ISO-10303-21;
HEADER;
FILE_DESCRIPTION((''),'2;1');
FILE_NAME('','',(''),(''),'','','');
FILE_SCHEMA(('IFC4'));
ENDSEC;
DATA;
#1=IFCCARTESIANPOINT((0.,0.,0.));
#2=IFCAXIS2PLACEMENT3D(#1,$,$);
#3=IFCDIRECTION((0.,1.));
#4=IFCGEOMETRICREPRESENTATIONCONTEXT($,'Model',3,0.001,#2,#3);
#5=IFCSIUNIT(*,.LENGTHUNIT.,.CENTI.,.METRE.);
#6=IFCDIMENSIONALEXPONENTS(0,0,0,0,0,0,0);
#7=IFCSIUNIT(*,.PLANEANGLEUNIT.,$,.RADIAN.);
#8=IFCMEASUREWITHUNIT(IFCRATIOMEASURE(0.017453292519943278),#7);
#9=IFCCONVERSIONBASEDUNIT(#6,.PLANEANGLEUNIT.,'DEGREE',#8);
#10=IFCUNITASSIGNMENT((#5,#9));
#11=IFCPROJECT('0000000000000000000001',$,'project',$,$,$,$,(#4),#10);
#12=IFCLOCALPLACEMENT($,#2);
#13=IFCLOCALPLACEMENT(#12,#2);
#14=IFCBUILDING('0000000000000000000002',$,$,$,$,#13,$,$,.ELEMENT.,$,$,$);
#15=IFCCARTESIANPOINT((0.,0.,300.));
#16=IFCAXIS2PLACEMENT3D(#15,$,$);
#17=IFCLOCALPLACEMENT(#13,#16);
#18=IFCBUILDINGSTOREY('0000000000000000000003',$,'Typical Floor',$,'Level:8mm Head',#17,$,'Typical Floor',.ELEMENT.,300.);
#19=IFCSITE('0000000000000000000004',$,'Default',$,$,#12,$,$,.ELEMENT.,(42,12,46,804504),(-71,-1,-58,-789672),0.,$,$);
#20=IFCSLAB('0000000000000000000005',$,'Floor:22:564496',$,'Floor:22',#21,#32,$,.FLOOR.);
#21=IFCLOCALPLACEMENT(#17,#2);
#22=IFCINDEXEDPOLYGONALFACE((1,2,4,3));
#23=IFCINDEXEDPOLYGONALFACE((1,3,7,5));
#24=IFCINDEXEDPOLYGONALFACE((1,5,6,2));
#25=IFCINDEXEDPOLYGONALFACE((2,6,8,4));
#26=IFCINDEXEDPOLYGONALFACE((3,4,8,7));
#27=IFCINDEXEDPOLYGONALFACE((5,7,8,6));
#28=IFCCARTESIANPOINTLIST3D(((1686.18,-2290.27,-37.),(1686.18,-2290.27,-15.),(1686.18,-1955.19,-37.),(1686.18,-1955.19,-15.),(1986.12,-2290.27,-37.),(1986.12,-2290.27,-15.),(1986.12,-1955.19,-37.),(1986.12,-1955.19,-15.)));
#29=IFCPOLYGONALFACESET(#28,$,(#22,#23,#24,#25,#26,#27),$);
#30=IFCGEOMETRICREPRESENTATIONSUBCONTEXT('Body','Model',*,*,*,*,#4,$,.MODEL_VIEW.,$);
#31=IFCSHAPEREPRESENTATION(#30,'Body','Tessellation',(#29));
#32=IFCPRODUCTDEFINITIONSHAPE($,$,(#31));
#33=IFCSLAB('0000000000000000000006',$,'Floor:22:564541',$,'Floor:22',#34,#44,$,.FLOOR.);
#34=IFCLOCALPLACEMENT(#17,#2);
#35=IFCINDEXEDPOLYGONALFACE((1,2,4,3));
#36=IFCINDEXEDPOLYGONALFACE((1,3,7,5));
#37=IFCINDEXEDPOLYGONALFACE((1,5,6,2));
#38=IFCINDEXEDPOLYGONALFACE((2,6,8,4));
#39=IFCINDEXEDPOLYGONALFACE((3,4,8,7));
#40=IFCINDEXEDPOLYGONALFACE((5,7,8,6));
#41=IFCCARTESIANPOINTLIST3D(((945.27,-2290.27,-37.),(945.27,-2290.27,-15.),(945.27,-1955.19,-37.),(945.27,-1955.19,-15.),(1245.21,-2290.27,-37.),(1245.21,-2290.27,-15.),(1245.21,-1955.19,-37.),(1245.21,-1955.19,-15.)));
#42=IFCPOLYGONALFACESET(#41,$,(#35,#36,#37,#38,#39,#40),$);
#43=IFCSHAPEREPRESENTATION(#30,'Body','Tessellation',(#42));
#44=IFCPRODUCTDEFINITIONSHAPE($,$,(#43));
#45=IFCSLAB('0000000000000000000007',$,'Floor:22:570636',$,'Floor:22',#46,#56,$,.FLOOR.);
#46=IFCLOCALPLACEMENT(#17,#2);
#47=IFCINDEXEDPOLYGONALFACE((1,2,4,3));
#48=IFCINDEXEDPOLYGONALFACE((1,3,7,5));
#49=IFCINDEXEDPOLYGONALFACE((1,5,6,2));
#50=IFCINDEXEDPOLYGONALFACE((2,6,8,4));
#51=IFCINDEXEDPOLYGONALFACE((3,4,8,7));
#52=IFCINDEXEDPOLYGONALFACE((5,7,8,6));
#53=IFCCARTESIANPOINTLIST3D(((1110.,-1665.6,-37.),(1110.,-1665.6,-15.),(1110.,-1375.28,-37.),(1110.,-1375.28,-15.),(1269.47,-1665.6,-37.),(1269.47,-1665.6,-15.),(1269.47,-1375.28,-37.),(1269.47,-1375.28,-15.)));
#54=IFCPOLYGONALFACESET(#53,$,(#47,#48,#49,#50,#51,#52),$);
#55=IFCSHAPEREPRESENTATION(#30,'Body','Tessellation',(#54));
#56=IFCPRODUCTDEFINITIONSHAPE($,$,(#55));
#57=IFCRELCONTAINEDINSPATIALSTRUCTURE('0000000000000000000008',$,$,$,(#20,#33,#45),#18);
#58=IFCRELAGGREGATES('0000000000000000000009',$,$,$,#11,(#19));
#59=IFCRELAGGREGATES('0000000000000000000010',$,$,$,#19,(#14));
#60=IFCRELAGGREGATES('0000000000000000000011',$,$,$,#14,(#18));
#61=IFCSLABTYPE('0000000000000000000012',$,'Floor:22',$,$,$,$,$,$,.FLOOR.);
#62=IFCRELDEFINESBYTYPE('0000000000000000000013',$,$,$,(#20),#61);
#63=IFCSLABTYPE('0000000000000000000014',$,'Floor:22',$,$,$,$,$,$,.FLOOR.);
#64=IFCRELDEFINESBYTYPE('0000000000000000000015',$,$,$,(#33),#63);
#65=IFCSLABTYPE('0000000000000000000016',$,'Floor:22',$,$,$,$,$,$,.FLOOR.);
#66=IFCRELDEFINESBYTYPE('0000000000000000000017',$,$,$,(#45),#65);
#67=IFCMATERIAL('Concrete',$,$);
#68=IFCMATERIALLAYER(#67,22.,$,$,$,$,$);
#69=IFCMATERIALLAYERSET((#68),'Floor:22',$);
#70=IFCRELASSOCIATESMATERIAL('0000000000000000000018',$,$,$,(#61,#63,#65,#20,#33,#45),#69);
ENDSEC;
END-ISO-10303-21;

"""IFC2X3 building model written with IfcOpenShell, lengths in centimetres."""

from ifc_helpers import new_model, entity, si_unit, converted_unit, direction, frame, frame_2d, origin, origin_2d_with_axis, place, context, subcontext, project, spatial, rectangle, extrude, material, layer, layer_set, layer_usage, type_object, element, save


model = new_model("IFC2X3")

# Units and contexts
model_context = context("Model", 3, precision=0.001, world=origin(), true_north=direction((0.0, 1.0)))
body_context = subcontext(model_context, "Body", "Model", "MODEL_VIEW")
ifc_project = project(units=[si_unit("LENGTHUNIT", "METRE", prefix="CENTI"), converted_unit("PLANEANGLEUNIT", "DEGREE", entity("IfcRatioMeasure", 0.017453292519943278), si_unit("PLANEANGLEUNIT", "RADIAN"), dimensions=[0, 0, 0, 0, 0, 0, 0])], contexts=[model_context])

# Site, building, storey
site_placement = place(None, origin())
site = spatial("IfcSite", under=ifc_project, at=site_placement, Name="Default", CompositionType="ELEMENT", RefLatitude=(42, 12, 46, 804504), RefLongitude=(-71, -1, -58, -789672), RefElevation=0.0)
building_placement = place(site_placement, origin())
building = spatial("IfcBuilding", under=site, at=building_placement, CompositionType="ELEMENT")
storey_placement = place(building_placement, frame((0.0, 0.0, 300.0)))
storey = spatial("IfcBuildingStorey", under=building, at=storey_placement, Name="Typical Floor", ObjectType="Level:8mm Head", LongName="Typical Floor", CompositionType="ELEMENT", Elevation=300.0)

# Slabs
ifc_material = material(Name="Concrete")
ifc_layer_1 = layer(ifc_material, 22.0)
ifc_layer_set_1 = layer_set([ifc_layer_1], Name="Floor:22")
ifc_layer_usage_1 = layer_usage(ifc_layer_set_1, "AXIS3", "POSITIVE", 0.0)
slab_type_1 = type_object("IfcSlabType", Name="Floor:22", PredefinedType="FLOOR", material=ifc_layer_set_1)
slab_1_placement = place(storey_placement, origin())
element("IfcSlab", 1, at=slab_1_placement, inside=storey, type_object=slab_type_1, material=ifc_layer_usage_1, Name="Floor:22:564496", ObjectType="Floor:22", PredefinedType="FLOOR", context=body_context, shape_type="SweptSolid", body=[
    extrude(rectangle(XDim=335.08, YDim=299.94, at=frame_2d((0.0, 0.0), x_axis=(1.0, 0.0))), frame((1836.15, -2122.73, -15.0), z_axis=(0.0, 0.0, -1.0), x_axis=(0.0, 1.0, 0.0)), (0.0, 0.0, 1.0), 22.0),
])
ifc_layer_usage_2 = layer_usage(ifc_layer_set_1, "AXIS3", "POSITIVE", 0.0)
slab_type_2 = type_object("IfcSlabType", Name="Floor:22", PredefinedType="FLOOR", material=ifc_layer_set_1)
slab_2_placement = place(storey_placement, origin())
element("IfcSlab", 2, at=slab_2_placement, inside=storey, type_object=slab_type_2, material=ifc_layer_usage_2, Name="Floor:22:564541", ObjectType="Floor:22", PredefinedType="FLOOR", context=body_context, shape_type="SweptSolid", body=[
    extrude(rectangle(XDim=335.08, YDim=299.94, at=frame_2d((0.0, 0.0), x_axis=(1.0, 0.0))), frame((1095.24, -2122.73, -15.0), z_axis=(0.0, 0.0, -1.0), x_axis=(0.0, 1.0, 0.0)), (0.0, 0.0, 1.0), 22.0),
])
ifc_layer_usage_3 = layer_usage(ifc_layer_set_1, "AXIS3", "POSITIVE", 0.0)
slab_type_3 = type_object("IfcSlabType", Name="Floor:22", PredefinedType="FLOOR", material=ifc_layer_set_1)
slab_3_placement = place(storey_placement, origin())
element("IfcSlab", 3, at=slab_3_placement, inside=storey, type_object=slab_type_3, material=ifc_layer_usage_3, Name="Floor:22:570636", ObjectType="Floor:22", PredefinedType="FLOOR", context=body_context, shape_type="SweptSolid", body=[
    extrude(rectangle(XDim=159.47, YDim=290.32, at=origin_2d_with_axis()), frame((1189.74, -1520.44, -15.0), z_axis=(0.0, 0.0, -1.0), x_axis=(1.0, 0.0, 0.0)), (0.0, 0.0, 1.0), 22.0),
])

save(model, "model.ifc")
